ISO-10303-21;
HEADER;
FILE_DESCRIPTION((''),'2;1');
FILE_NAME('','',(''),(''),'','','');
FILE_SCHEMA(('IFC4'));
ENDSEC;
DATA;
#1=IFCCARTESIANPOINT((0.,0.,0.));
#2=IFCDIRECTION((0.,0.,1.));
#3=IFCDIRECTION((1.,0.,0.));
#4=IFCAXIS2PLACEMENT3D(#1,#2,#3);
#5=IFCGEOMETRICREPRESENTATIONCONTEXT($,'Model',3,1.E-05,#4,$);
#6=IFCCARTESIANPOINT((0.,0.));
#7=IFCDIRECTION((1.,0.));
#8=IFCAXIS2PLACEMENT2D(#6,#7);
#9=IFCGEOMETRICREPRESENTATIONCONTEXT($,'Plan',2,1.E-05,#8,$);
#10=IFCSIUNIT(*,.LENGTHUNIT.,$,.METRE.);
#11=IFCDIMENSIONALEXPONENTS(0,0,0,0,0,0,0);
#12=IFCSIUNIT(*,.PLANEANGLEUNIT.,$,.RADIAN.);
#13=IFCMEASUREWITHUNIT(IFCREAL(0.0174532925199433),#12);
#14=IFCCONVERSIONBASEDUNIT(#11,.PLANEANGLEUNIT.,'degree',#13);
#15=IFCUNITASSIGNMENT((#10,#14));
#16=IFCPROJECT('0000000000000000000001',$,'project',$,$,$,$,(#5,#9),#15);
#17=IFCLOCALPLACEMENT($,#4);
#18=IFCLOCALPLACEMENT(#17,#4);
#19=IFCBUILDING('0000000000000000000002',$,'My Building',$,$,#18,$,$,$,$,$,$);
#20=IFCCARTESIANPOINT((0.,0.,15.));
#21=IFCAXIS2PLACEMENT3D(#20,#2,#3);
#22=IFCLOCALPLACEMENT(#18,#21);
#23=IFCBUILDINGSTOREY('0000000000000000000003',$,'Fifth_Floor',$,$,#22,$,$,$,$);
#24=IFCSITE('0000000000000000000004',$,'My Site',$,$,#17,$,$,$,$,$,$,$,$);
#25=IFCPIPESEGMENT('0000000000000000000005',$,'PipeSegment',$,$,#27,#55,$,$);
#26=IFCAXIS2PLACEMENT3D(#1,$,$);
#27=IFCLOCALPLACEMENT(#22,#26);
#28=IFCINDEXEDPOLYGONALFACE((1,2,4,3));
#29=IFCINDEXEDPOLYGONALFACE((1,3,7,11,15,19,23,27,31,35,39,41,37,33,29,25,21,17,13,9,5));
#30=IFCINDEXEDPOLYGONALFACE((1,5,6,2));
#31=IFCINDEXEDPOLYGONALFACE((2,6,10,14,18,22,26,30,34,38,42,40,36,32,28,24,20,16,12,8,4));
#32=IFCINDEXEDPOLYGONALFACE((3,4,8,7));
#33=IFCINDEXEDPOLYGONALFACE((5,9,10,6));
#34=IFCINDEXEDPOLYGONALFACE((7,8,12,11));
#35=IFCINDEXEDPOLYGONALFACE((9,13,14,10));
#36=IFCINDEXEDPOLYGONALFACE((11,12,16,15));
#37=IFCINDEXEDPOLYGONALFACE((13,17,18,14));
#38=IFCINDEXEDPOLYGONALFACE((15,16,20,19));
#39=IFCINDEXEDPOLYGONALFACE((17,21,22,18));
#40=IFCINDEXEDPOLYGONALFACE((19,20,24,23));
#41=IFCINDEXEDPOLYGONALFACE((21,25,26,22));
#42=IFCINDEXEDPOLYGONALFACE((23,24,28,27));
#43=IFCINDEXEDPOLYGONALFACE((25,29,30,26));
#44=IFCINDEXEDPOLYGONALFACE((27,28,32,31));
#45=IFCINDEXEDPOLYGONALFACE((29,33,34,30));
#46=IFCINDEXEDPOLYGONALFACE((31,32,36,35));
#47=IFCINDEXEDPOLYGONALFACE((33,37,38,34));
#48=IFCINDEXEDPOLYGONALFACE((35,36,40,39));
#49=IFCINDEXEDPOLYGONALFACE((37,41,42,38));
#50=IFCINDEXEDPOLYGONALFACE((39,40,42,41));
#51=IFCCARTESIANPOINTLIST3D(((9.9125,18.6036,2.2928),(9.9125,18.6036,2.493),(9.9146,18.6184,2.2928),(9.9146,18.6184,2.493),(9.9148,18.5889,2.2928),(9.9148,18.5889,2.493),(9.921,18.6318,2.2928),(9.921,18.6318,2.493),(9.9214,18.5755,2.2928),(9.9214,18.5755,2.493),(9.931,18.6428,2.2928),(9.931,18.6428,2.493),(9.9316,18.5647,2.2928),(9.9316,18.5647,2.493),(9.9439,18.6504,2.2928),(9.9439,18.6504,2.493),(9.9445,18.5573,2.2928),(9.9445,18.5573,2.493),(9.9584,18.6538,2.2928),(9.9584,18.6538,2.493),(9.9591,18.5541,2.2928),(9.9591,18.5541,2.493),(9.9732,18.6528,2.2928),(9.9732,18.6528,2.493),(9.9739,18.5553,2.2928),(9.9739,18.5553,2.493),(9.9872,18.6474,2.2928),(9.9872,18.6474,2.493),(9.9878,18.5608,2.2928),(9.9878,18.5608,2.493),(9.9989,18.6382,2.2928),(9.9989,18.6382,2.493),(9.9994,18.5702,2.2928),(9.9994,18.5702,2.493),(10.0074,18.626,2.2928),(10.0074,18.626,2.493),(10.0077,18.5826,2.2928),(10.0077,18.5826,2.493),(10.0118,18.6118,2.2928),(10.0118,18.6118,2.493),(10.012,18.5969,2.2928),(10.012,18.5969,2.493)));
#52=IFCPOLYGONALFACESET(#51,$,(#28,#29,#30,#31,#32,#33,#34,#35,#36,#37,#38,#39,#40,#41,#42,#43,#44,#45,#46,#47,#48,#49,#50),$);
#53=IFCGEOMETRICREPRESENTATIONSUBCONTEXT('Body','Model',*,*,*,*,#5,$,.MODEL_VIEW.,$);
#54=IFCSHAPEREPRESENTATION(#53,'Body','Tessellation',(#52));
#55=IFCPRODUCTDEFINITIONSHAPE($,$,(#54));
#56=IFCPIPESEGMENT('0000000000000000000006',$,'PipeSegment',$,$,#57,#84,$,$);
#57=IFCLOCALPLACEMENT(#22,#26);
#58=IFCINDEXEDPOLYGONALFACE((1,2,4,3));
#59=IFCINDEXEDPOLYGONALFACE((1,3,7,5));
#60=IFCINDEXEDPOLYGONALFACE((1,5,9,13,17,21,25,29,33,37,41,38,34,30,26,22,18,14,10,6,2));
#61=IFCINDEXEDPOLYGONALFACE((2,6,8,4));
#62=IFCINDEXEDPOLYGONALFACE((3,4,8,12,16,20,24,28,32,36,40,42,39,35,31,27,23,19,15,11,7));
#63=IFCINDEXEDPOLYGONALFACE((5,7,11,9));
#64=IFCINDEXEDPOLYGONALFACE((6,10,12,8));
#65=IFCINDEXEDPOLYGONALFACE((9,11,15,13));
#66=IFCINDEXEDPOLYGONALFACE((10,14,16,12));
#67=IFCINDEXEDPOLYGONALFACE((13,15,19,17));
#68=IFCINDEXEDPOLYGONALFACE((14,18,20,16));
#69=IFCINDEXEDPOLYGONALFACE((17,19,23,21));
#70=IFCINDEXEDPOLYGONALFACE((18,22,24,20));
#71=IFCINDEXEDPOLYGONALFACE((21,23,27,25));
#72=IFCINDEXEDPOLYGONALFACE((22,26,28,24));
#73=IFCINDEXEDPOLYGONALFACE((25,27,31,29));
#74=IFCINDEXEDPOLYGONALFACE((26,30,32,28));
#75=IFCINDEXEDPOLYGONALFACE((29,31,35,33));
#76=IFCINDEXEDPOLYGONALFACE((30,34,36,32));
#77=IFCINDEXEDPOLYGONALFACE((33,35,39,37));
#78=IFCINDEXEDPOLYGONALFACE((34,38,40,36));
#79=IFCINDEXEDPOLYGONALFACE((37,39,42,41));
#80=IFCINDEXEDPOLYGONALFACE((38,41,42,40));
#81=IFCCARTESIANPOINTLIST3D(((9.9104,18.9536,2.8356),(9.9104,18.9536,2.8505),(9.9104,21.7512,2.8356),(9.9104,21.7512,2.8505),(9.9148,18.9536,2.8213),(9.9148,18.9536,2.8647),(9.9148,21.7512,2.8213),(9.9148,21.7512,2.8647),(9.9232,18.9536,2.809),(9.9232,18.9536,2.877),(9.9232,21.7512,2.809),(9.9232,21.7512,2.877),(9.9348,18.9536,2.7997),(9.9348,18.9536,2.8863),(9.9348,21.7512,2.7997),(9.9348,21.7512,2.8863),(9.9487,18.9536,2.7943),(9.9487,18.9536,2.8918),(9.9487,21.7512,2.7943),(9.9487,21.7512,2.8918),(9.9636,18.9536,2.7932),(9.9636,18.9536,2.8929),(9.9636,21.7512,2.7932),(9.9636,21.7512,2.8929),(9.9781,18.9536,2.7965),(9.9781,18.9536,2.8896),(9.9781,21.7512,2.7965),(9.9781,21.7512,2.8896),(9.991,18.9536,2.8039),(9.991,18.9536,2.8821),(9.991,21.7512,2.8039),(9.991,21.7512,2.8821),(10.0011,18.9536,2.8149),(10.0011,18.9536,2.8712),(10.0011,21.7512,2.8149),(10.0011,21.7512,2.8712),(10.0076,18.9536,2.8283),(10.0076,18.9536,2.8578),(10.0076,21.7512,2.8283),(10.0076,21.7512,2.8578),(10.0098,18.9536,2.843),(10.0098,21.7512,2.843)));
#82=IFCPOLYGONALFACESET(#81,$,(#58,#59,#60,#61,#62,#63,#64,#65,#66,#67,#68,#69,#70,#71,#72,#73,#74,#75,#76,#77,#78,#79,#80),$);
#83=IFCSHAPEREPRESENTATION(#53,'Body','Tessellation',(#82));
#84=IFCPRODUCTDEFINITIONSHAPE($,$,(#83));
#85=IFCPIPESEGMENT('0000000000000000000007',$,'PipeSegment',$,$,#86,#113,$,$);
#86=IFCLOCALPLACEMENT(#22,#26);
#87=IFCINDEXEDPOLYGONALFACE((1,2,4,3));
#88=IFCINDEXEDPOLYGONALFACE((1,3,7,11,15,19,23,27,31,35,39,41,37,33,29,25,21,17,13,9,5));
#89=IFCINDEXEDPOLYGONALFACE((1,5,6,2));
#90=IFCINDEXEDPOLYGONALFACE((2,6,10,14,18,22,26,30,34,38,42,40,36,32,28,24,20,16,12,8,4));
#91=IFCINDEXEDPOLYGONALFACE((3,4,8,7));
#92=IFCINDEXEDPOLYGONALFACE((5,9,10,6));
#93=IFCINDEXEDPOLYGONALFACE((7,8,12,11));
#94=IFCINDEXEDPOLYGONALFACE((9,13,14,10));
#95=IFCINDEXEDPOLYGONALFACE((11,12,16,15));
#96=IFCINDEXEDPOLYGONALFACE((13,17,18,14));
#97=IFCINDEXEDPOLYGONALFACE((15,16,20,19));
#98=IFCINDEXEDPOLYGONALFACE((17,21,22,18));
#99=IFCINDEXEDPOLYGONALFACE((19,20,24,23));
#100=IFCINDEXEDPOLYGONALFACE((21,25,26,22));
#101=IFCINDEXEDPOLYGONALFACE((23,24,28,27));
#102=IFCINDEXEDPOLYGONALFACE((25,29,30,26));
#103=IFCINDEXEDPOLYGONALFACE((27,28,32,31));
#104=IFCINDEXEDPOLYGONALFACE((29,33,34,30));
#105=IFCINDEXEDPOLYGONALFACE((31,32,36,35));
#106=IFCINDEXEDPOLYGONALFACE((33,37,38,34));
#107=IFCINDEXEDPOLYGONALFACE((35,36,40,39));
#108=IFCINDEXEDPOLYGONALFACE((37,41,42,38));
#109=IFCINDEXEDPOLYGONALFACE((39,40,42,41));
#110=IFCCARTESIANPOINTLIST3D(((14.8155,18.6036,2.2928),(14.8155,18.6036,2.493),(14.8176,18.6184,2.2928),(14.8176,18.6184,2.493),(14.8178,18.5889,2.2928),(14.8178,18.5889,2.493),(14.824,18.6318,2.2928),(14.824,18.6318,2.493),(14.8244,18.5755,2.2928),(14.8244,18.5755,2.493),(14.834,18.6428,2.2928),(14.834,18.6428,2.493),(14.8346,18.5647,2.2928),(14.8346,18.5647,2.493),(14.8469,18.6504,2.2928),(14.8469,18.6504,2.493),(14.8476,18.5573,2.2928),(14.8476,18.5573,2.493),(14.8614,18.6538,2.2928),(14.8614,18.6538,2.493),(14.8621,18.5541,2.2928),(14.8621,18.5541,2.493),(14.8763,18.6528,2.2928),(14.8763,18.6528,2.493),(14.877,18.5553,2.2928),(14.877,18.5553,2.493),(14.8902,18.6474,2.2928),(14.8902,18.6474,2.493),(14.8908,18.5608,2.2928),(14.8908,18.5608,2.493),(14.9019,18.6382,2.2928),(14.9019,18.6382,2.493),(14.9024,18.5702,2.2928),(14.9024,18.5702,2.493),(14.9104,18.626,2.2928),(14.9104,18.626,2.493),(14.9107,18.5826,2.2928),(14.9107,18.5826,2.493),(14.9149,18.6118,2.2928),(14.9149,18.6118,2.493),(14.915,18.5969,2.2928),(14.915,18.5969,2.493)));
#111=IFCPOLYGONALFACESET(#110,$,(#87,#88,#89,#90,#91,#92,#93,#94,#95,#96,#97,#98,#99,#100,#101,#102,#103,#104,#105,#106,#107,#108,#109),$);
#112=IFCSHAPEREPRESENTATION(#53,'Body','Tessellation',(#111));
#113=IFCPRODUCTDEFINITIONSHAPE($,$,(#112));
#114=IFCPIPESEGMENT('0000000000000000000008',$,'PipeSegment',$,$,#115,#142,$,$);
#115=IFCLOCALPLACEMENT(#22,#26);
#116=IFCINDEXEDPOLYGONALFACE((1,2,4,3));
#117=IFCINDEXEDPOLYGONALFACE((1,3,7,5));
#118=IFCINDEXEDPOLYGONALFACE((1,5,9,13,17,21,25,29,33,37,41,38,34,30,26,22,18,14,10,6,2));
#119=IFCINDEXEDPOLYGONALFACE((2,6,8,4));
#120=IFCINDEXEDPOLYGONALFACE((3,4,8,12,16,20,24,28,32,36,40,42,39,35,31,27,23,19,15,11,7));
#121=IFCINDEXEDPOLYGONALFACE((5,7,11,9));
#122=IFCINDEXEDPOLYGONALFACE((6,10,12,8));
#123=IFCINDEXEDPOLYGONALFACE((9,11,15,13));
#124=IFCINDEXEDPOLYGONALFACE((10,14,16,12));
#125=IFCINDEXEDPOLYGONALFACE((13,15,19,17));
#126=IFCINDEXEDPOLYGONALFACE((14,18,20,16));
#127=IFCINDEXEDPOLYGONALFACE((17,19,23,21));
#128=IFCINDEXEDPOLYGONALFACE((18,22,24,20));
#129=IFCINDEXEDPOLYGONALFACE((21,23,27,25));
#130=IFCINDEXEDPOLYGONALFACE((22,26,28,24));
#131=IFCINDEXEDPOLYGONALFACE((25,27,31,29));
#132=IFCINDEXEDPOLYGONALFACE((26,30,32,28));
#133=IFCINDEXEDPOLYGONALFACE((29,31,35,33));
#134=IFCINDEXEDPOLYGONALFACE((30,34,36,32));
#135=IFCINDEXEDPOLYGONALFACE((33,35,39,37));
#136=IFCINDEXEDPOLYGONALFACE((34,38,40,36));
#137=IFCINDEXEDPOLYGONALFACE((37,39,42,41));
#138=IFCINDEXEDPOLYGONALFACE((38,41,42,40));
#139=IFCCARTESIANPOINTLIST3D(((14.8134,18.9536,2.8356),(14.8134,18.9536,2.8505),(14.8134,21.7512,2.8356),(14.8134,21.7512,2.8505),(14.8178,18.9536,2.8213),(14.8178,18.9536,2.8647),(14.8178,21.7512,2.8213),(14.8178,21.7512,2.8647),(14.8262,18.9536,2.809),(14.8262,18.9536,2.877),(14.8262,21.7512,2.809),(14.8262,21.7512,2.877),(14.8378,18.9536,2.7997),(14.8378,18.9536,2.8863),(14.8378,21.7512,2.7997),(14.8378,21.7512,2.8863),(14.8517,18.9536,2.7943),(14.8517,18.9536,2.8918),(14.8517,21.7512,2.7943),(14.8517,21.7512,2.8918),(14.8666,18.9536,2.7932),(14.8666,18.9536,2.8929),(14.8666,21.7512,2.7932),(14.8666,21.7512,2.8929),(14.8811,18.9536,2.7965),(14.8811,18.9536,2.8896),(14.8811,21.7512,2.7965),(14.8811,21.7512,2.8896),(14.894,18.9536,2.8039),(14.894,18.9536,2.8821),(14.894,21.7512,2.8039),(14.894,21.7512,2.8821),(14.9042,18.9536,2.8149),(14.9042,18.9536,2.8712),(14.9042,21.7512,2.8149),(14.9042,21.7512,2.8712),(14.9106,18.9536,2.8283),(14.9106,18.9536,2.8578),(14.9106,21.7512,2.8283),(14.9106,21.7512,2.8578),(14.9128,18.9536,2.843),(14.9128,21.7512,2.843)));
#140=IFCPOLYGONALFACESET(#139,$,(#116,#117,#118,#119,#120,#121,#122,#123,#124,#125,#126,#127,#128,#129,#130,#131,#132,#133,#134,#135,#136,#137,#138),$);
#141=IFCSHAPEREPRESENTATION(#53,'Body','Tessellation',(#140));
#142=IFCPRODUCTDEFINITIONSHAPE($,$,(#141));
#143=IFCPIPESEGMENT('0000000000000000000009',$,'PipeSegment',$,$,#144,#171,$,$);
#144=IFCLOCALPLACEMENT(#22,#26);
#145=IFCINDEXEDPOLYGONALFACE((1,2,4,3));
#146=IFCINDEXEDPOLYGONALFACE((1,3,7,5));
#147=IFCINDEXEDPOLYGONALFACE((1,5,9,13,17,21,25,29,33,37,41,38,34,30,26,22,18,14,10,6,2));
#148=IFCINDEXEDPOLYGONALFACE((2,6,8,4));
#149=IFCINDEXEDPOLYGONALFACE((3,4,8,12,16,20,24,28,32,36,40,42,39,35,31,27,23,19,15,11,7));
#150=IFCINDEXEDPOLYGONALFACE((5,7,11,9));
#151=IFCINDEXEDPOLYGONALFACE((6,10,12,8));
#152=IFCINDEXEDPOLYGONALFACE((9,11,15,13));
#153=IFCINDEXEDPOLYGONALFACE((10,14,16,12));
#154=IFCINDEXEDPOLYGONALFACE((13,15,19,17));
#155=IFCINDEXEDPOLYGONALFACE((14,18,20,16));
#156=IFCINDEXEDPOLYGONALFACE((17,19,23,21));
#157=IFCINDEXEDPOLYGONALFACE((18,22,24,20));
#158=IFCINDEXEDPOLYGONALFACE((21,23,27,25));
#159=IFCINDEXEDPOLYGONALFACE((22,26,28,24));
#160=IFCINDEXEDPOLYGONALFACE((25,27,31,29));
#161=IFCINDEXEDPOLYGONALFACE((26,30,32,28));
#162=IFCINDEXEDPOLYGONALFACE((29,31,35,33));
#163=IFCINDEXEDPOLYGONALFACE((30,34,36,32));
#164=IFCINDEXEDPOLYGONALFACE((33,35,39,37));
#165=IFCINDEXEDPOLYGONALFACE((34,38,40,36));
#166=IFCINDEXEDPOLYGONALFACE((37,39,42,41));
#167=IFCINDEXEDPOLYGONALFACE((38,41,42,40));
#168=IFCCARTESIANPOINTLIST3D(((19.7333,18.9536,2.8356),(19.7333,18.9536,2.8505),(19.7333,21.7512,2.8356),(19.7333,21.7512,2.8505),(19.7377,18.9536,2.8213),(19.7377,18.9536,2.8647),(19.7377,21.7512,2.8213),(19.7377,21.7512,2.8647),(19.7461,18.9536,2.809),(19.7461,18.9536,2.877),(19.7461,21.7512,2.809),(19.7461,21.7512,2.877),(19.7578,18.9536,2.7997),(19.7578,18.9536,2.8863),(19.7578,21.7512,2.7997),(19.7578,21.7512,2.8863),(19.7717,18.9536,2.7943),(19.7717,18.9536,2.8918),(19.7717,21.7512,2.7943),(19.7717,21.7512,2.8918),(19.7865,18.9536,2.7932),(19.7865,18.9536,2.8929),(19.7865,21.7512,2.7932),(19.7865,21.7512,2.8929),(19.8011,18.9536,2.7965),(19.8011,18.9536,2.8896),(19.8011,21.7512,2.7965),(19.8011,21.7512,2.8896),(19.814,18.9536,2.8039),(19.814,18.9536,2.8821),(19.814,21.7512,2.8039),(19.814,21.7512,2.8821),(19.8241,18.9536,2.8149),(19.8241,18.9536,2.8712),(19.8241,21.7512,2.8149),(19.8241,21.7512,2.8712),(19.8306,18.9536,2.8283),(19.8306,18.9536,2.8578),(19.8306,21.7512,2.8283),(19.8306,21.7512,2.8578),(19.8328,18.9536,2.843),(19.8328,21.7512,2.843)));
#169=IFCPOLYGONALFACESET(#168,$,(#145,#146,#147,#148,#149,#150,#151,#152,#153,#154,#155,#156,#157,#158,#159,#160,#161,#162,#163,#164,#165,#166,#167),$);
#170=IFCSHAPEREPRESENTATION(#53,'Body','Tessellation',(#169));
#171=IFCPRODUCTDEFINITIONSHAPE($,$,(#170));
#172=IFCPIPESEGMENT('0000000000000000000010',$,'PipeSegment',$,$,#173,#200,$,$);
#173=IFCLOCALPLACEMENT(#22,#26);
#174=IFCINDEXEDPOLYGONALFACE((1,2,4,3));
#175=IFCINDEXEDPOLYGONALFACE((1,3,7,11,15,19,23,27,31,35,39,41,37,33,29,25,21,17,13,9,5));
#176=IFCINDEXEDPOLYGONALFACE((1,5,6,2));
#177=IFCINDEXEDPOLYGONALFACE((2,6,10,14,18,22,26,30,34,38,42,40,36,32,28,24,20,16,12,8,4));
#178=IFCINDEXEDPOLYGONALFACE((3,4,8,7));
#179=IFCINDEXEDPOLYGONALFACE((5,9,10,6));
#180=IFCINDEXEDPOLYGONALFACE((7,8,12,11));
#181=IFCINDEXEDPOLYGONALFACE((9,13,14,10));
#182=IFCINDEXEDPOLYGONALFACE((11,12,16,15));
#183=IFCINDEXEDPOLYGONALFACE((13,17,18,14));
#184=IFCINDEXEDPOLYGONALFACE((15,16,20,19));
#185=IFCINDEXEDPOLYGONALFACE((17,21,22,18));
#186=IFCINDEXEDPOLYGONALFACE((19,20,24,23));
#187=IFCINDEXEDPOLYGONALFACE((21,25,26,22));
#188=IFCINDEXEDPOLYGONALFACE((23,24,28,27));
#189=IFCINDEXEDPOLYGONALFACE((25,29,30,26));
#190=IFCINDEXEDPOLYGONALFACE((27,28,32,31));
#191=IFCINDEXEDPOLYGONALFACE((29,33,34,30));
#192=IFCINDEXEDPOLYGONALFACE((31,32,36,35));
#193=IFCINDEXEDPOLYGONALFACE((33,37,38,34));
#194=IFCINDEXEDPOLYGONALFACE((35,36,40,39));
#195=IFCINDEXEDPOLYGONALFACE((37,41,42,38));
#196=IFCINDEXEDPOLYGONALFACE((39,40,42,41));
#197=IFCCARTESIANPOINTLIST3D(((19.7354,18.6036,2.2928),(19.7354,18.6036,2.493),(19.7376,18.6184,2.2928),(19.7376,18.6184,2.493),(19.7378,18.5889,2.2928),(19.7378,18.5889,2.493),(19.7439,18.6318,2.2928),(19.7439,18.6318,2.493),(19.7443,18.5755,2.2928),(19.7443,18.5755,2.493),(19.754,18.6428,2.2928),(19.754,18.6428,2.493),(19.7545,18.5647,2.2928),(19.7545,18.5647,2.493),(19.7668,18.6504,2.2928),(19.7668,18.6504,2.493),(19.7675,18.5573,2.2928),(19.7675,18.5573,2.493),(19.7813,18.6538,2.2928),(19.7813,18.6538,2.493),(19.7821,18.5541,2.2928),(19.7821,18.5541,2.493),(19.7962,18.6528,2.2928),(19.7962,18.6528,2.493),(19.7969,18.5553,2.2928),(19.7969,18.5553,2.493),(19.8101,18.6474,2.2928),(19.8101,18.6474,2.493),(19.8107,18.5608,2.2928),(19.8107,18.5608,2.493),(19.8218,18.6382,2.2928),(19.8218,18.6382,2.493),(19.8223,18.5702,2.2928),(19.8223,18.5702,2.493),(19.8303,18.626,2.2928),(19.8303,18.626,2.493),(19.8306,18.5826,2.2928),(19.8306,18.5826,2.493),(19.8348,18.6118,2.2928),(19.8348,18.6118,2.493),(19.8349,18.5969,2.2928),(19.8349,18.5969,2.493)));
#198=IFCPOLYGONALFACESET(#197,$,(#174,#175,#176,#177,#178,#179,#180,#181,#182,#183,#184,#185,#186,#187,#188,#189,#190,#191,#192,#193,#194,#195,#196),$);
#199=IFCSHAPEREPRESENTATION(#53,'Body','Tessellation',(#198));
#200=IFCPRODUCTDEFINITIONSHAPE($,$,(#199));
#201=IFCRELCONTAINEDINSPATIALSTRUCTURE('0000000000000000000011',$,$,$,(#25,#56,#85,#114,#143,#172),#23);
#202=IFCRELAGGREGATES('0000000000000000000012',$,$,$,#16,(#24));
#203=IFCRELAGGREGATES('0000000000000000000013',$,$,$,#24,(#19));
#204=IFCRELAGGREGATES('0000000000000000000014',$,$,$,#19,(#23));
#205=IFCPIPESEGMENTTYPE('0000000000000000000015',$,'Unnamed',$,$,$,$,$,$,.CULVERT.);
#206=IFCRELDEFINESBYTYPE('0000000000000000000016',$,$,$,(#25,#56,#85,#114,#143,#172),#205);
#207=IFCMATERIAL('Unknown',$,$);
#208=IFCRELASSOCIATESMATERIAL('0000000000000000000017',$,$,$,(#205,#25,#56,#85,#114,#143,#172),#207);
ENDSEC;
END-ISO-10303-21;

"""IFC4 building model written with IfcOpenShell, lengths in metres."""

from ifc_helpers import new_model, entity, si_unit, converted_unit, frame, origin_with_axes, origin_2d_with_axis, place, context, subcontext, project, spatial, circle, extrude, material, material_profile, profile_set, profile_usage, type_object, element, save


model = new_model("IFC4")

# Units and contexts
model_context = context("Model", 3, precision=1e-05, world=origin_with_axes())
plan_context = context("Plan", 2, precision=1e-05, world=origin_2d_with_axis())
body_context_1 = subcontext(model_context, "Body", "Model", "MODEL_VIEW")
ifc_project = project(units=[si_unit("LENGTHUNIT", "METRE"), converted_unit("PLANEANGLEUNIT", "degree", entity("IfcReal", 0.0174532925199433), si_unit("PLANEANGLEUNIT", "RADIAN"), dimensions=[0, 0, 0, 0, 0, 0, 0])], contexts=[model_context, plan_context])

# Site, building, storey
site_placement = place(None, origin_with_axes())
site = spatial("IfcSite", under=ifc_project, at=site_placement, Name="My Site")
building_placement = place(site_placement, origin_with_axes())
building = spatial("IfcBuilding", under=site, at=building_placement, Name="My Building")
storey_placement = place(building_placement, frame((0.0, 0.0, 15.0), z_axis=(0.0, 0.0, 1.0), x_axis=(1.0, 0.0, 0.0)))
storey = spatial("IfcBuildingStorey", under=building, at=storey_placement, Name="Fifth_Floor")

# Shared definitions
ifc_material = material(Name="Unknown")

# Pipe segments
ifc_material_profile_1 = material_profile(ifc_material, circle(Radius=0.05))
ifc_profile_set_1 = profile_set([ifc_material_profile_1])
ifc_profile_usage_1 = profile_usage(ifc_profile_set_1, cardinal=5)
pipe_segment_type = type_object("IfcPipeSegmentType", Name="Unnamed", PredefinedType="CULVERT", material=ifc_profile_set_1)
pipe_segment_1_placement = place(storey_placement, frame((9.9625, 18.604, 2.493), z_axis=(-0.000001, 0.0, -1.0), x_axis=(-0.999975, -0.007084, 0.000001)))
element("IfcPipeSegment", 1, at=pipe_segment_1_placement, inside=storey, type_object=pipe_segment_type, material=ifc_profile_usage_1, Name="PipeSegment", context=body_context_1, shape_type="SweptSolid", body=[
    extrude(circle(Radius=0.05), origin_with_axes(), (0.0, 0.0, 1.0), 0.2002),
])
ifc_profile_usage_2 = profile_usage(ifc_profile_set_1, cardinal=5)
pipe_segment_2_placement = place(storey_placement, frame((9.9598, 21.7512, 2.843), z_axis=(0.0, -1.0, 0.0), x_axis=(1.0, 0.0, 0.0)))
element("IfcPipeSegment", 2, at=pipe_segment_2_placement, inside=storey, type_object=pipe_segment_type, material=ifc_profile_usage_2, Name="PipeSegment", context=body_context_1, shape_type="SweptSolid", body=[
    extrude(circle(Radius=0.05), origin_with_axes(), (0.0, 0.0, 1.0), 2.7976),
])
ifc_profile_usage_3 = profile_usage(ifc_profile_set_1, cardinal=5)
pipe_segment_3_placement = place(storey_placement, frame((14.8655, 18.604, 2.493), z_axis=(-0.000001, 0.0, -1.0), x_axis=(-0.999975, -0.007084, 0.000001)))
element("IfcPipeSegment", 3, at=pipe_segment_3_placement, inside=storey, type_object=pipe_segment_type, material=ifc_profile_usage_3, Name="PipeSegment", context=body_context_1, shape_type="SweptSolid", body=[
    extrude(circle(Radius=0.05), origin_with_axes(), (0.0, 0.0, 1.0), 0.2002),
])
ifc_profile_usage_4 = profile_usage(ifc_profile_set_1, cardinal=5)
pipe_segment_4_placement = place(storey_placement, frame((14.8628, 21.7512, 2.843), z_axis=(0.0, -1.0, 0.0), x_axis=(1.0, 0.0, 0.0)))
element("IfcPipeSegment", 4, at=pipe_segment_4_placement, inside=storey, type_object=pipe_segment_type, material=ifc_profile_usage_4, Name="PipeSegment", context=body_context_1, shape_type="SweptSolid", body=[
    extrude(circle(Radius=0.05), origin_with_axes(), (0.0, 0.0, 1.0), 2.7976),
])
ifc_profile_usage_5 = profile_usage(ifc_profile_set_1, cardinal=5)
pipe_segment_5_placement = place(storey_placement, frame((19.7828, 21.7512, 2.843), z_axis=(0.0, -1.0, 0.0), x_axis=(1.0, 0.0, 0.0)))
element("IfcPipeSegment", 5, at=pipe_segment_5_placement, inside=storey, type_object=pipe_segment_type, material=ifc_profile_usage_5, Name="PipeSegment", context=body_context_1, shape_type="SweptSolid", body=[
    extrude(circle(Radius=0.05), origin_with_axes(), (0.0, 0.0, 1.0), 2.7976),
])
ifc_profile_usage_6 = profile_usage(ifc_profile_set_1, cardinal=5)
pipe_segment_6_placement = place(storey_placement, frame((19.7854, 18.604, 2.493), z_axis=(-0.000001, 0.0, -1.0), x_axis=(-0.999975, -0.007084, 0.000001)))
element("IfcPipeSegment", 6, at=pipe_segment_6_placement, inside=storey, type_object=pipe_segment_type, material=ifc_profile_usage_6, Name="PipeSegment", context=body_context_1, shape_type="SweptSolid", body=[
    extrude(circle(Radius=0.05), origin_with_axes(), (0.0, 0.0, 1.0), 0.2002),
])

save(model, "model.ifc")
